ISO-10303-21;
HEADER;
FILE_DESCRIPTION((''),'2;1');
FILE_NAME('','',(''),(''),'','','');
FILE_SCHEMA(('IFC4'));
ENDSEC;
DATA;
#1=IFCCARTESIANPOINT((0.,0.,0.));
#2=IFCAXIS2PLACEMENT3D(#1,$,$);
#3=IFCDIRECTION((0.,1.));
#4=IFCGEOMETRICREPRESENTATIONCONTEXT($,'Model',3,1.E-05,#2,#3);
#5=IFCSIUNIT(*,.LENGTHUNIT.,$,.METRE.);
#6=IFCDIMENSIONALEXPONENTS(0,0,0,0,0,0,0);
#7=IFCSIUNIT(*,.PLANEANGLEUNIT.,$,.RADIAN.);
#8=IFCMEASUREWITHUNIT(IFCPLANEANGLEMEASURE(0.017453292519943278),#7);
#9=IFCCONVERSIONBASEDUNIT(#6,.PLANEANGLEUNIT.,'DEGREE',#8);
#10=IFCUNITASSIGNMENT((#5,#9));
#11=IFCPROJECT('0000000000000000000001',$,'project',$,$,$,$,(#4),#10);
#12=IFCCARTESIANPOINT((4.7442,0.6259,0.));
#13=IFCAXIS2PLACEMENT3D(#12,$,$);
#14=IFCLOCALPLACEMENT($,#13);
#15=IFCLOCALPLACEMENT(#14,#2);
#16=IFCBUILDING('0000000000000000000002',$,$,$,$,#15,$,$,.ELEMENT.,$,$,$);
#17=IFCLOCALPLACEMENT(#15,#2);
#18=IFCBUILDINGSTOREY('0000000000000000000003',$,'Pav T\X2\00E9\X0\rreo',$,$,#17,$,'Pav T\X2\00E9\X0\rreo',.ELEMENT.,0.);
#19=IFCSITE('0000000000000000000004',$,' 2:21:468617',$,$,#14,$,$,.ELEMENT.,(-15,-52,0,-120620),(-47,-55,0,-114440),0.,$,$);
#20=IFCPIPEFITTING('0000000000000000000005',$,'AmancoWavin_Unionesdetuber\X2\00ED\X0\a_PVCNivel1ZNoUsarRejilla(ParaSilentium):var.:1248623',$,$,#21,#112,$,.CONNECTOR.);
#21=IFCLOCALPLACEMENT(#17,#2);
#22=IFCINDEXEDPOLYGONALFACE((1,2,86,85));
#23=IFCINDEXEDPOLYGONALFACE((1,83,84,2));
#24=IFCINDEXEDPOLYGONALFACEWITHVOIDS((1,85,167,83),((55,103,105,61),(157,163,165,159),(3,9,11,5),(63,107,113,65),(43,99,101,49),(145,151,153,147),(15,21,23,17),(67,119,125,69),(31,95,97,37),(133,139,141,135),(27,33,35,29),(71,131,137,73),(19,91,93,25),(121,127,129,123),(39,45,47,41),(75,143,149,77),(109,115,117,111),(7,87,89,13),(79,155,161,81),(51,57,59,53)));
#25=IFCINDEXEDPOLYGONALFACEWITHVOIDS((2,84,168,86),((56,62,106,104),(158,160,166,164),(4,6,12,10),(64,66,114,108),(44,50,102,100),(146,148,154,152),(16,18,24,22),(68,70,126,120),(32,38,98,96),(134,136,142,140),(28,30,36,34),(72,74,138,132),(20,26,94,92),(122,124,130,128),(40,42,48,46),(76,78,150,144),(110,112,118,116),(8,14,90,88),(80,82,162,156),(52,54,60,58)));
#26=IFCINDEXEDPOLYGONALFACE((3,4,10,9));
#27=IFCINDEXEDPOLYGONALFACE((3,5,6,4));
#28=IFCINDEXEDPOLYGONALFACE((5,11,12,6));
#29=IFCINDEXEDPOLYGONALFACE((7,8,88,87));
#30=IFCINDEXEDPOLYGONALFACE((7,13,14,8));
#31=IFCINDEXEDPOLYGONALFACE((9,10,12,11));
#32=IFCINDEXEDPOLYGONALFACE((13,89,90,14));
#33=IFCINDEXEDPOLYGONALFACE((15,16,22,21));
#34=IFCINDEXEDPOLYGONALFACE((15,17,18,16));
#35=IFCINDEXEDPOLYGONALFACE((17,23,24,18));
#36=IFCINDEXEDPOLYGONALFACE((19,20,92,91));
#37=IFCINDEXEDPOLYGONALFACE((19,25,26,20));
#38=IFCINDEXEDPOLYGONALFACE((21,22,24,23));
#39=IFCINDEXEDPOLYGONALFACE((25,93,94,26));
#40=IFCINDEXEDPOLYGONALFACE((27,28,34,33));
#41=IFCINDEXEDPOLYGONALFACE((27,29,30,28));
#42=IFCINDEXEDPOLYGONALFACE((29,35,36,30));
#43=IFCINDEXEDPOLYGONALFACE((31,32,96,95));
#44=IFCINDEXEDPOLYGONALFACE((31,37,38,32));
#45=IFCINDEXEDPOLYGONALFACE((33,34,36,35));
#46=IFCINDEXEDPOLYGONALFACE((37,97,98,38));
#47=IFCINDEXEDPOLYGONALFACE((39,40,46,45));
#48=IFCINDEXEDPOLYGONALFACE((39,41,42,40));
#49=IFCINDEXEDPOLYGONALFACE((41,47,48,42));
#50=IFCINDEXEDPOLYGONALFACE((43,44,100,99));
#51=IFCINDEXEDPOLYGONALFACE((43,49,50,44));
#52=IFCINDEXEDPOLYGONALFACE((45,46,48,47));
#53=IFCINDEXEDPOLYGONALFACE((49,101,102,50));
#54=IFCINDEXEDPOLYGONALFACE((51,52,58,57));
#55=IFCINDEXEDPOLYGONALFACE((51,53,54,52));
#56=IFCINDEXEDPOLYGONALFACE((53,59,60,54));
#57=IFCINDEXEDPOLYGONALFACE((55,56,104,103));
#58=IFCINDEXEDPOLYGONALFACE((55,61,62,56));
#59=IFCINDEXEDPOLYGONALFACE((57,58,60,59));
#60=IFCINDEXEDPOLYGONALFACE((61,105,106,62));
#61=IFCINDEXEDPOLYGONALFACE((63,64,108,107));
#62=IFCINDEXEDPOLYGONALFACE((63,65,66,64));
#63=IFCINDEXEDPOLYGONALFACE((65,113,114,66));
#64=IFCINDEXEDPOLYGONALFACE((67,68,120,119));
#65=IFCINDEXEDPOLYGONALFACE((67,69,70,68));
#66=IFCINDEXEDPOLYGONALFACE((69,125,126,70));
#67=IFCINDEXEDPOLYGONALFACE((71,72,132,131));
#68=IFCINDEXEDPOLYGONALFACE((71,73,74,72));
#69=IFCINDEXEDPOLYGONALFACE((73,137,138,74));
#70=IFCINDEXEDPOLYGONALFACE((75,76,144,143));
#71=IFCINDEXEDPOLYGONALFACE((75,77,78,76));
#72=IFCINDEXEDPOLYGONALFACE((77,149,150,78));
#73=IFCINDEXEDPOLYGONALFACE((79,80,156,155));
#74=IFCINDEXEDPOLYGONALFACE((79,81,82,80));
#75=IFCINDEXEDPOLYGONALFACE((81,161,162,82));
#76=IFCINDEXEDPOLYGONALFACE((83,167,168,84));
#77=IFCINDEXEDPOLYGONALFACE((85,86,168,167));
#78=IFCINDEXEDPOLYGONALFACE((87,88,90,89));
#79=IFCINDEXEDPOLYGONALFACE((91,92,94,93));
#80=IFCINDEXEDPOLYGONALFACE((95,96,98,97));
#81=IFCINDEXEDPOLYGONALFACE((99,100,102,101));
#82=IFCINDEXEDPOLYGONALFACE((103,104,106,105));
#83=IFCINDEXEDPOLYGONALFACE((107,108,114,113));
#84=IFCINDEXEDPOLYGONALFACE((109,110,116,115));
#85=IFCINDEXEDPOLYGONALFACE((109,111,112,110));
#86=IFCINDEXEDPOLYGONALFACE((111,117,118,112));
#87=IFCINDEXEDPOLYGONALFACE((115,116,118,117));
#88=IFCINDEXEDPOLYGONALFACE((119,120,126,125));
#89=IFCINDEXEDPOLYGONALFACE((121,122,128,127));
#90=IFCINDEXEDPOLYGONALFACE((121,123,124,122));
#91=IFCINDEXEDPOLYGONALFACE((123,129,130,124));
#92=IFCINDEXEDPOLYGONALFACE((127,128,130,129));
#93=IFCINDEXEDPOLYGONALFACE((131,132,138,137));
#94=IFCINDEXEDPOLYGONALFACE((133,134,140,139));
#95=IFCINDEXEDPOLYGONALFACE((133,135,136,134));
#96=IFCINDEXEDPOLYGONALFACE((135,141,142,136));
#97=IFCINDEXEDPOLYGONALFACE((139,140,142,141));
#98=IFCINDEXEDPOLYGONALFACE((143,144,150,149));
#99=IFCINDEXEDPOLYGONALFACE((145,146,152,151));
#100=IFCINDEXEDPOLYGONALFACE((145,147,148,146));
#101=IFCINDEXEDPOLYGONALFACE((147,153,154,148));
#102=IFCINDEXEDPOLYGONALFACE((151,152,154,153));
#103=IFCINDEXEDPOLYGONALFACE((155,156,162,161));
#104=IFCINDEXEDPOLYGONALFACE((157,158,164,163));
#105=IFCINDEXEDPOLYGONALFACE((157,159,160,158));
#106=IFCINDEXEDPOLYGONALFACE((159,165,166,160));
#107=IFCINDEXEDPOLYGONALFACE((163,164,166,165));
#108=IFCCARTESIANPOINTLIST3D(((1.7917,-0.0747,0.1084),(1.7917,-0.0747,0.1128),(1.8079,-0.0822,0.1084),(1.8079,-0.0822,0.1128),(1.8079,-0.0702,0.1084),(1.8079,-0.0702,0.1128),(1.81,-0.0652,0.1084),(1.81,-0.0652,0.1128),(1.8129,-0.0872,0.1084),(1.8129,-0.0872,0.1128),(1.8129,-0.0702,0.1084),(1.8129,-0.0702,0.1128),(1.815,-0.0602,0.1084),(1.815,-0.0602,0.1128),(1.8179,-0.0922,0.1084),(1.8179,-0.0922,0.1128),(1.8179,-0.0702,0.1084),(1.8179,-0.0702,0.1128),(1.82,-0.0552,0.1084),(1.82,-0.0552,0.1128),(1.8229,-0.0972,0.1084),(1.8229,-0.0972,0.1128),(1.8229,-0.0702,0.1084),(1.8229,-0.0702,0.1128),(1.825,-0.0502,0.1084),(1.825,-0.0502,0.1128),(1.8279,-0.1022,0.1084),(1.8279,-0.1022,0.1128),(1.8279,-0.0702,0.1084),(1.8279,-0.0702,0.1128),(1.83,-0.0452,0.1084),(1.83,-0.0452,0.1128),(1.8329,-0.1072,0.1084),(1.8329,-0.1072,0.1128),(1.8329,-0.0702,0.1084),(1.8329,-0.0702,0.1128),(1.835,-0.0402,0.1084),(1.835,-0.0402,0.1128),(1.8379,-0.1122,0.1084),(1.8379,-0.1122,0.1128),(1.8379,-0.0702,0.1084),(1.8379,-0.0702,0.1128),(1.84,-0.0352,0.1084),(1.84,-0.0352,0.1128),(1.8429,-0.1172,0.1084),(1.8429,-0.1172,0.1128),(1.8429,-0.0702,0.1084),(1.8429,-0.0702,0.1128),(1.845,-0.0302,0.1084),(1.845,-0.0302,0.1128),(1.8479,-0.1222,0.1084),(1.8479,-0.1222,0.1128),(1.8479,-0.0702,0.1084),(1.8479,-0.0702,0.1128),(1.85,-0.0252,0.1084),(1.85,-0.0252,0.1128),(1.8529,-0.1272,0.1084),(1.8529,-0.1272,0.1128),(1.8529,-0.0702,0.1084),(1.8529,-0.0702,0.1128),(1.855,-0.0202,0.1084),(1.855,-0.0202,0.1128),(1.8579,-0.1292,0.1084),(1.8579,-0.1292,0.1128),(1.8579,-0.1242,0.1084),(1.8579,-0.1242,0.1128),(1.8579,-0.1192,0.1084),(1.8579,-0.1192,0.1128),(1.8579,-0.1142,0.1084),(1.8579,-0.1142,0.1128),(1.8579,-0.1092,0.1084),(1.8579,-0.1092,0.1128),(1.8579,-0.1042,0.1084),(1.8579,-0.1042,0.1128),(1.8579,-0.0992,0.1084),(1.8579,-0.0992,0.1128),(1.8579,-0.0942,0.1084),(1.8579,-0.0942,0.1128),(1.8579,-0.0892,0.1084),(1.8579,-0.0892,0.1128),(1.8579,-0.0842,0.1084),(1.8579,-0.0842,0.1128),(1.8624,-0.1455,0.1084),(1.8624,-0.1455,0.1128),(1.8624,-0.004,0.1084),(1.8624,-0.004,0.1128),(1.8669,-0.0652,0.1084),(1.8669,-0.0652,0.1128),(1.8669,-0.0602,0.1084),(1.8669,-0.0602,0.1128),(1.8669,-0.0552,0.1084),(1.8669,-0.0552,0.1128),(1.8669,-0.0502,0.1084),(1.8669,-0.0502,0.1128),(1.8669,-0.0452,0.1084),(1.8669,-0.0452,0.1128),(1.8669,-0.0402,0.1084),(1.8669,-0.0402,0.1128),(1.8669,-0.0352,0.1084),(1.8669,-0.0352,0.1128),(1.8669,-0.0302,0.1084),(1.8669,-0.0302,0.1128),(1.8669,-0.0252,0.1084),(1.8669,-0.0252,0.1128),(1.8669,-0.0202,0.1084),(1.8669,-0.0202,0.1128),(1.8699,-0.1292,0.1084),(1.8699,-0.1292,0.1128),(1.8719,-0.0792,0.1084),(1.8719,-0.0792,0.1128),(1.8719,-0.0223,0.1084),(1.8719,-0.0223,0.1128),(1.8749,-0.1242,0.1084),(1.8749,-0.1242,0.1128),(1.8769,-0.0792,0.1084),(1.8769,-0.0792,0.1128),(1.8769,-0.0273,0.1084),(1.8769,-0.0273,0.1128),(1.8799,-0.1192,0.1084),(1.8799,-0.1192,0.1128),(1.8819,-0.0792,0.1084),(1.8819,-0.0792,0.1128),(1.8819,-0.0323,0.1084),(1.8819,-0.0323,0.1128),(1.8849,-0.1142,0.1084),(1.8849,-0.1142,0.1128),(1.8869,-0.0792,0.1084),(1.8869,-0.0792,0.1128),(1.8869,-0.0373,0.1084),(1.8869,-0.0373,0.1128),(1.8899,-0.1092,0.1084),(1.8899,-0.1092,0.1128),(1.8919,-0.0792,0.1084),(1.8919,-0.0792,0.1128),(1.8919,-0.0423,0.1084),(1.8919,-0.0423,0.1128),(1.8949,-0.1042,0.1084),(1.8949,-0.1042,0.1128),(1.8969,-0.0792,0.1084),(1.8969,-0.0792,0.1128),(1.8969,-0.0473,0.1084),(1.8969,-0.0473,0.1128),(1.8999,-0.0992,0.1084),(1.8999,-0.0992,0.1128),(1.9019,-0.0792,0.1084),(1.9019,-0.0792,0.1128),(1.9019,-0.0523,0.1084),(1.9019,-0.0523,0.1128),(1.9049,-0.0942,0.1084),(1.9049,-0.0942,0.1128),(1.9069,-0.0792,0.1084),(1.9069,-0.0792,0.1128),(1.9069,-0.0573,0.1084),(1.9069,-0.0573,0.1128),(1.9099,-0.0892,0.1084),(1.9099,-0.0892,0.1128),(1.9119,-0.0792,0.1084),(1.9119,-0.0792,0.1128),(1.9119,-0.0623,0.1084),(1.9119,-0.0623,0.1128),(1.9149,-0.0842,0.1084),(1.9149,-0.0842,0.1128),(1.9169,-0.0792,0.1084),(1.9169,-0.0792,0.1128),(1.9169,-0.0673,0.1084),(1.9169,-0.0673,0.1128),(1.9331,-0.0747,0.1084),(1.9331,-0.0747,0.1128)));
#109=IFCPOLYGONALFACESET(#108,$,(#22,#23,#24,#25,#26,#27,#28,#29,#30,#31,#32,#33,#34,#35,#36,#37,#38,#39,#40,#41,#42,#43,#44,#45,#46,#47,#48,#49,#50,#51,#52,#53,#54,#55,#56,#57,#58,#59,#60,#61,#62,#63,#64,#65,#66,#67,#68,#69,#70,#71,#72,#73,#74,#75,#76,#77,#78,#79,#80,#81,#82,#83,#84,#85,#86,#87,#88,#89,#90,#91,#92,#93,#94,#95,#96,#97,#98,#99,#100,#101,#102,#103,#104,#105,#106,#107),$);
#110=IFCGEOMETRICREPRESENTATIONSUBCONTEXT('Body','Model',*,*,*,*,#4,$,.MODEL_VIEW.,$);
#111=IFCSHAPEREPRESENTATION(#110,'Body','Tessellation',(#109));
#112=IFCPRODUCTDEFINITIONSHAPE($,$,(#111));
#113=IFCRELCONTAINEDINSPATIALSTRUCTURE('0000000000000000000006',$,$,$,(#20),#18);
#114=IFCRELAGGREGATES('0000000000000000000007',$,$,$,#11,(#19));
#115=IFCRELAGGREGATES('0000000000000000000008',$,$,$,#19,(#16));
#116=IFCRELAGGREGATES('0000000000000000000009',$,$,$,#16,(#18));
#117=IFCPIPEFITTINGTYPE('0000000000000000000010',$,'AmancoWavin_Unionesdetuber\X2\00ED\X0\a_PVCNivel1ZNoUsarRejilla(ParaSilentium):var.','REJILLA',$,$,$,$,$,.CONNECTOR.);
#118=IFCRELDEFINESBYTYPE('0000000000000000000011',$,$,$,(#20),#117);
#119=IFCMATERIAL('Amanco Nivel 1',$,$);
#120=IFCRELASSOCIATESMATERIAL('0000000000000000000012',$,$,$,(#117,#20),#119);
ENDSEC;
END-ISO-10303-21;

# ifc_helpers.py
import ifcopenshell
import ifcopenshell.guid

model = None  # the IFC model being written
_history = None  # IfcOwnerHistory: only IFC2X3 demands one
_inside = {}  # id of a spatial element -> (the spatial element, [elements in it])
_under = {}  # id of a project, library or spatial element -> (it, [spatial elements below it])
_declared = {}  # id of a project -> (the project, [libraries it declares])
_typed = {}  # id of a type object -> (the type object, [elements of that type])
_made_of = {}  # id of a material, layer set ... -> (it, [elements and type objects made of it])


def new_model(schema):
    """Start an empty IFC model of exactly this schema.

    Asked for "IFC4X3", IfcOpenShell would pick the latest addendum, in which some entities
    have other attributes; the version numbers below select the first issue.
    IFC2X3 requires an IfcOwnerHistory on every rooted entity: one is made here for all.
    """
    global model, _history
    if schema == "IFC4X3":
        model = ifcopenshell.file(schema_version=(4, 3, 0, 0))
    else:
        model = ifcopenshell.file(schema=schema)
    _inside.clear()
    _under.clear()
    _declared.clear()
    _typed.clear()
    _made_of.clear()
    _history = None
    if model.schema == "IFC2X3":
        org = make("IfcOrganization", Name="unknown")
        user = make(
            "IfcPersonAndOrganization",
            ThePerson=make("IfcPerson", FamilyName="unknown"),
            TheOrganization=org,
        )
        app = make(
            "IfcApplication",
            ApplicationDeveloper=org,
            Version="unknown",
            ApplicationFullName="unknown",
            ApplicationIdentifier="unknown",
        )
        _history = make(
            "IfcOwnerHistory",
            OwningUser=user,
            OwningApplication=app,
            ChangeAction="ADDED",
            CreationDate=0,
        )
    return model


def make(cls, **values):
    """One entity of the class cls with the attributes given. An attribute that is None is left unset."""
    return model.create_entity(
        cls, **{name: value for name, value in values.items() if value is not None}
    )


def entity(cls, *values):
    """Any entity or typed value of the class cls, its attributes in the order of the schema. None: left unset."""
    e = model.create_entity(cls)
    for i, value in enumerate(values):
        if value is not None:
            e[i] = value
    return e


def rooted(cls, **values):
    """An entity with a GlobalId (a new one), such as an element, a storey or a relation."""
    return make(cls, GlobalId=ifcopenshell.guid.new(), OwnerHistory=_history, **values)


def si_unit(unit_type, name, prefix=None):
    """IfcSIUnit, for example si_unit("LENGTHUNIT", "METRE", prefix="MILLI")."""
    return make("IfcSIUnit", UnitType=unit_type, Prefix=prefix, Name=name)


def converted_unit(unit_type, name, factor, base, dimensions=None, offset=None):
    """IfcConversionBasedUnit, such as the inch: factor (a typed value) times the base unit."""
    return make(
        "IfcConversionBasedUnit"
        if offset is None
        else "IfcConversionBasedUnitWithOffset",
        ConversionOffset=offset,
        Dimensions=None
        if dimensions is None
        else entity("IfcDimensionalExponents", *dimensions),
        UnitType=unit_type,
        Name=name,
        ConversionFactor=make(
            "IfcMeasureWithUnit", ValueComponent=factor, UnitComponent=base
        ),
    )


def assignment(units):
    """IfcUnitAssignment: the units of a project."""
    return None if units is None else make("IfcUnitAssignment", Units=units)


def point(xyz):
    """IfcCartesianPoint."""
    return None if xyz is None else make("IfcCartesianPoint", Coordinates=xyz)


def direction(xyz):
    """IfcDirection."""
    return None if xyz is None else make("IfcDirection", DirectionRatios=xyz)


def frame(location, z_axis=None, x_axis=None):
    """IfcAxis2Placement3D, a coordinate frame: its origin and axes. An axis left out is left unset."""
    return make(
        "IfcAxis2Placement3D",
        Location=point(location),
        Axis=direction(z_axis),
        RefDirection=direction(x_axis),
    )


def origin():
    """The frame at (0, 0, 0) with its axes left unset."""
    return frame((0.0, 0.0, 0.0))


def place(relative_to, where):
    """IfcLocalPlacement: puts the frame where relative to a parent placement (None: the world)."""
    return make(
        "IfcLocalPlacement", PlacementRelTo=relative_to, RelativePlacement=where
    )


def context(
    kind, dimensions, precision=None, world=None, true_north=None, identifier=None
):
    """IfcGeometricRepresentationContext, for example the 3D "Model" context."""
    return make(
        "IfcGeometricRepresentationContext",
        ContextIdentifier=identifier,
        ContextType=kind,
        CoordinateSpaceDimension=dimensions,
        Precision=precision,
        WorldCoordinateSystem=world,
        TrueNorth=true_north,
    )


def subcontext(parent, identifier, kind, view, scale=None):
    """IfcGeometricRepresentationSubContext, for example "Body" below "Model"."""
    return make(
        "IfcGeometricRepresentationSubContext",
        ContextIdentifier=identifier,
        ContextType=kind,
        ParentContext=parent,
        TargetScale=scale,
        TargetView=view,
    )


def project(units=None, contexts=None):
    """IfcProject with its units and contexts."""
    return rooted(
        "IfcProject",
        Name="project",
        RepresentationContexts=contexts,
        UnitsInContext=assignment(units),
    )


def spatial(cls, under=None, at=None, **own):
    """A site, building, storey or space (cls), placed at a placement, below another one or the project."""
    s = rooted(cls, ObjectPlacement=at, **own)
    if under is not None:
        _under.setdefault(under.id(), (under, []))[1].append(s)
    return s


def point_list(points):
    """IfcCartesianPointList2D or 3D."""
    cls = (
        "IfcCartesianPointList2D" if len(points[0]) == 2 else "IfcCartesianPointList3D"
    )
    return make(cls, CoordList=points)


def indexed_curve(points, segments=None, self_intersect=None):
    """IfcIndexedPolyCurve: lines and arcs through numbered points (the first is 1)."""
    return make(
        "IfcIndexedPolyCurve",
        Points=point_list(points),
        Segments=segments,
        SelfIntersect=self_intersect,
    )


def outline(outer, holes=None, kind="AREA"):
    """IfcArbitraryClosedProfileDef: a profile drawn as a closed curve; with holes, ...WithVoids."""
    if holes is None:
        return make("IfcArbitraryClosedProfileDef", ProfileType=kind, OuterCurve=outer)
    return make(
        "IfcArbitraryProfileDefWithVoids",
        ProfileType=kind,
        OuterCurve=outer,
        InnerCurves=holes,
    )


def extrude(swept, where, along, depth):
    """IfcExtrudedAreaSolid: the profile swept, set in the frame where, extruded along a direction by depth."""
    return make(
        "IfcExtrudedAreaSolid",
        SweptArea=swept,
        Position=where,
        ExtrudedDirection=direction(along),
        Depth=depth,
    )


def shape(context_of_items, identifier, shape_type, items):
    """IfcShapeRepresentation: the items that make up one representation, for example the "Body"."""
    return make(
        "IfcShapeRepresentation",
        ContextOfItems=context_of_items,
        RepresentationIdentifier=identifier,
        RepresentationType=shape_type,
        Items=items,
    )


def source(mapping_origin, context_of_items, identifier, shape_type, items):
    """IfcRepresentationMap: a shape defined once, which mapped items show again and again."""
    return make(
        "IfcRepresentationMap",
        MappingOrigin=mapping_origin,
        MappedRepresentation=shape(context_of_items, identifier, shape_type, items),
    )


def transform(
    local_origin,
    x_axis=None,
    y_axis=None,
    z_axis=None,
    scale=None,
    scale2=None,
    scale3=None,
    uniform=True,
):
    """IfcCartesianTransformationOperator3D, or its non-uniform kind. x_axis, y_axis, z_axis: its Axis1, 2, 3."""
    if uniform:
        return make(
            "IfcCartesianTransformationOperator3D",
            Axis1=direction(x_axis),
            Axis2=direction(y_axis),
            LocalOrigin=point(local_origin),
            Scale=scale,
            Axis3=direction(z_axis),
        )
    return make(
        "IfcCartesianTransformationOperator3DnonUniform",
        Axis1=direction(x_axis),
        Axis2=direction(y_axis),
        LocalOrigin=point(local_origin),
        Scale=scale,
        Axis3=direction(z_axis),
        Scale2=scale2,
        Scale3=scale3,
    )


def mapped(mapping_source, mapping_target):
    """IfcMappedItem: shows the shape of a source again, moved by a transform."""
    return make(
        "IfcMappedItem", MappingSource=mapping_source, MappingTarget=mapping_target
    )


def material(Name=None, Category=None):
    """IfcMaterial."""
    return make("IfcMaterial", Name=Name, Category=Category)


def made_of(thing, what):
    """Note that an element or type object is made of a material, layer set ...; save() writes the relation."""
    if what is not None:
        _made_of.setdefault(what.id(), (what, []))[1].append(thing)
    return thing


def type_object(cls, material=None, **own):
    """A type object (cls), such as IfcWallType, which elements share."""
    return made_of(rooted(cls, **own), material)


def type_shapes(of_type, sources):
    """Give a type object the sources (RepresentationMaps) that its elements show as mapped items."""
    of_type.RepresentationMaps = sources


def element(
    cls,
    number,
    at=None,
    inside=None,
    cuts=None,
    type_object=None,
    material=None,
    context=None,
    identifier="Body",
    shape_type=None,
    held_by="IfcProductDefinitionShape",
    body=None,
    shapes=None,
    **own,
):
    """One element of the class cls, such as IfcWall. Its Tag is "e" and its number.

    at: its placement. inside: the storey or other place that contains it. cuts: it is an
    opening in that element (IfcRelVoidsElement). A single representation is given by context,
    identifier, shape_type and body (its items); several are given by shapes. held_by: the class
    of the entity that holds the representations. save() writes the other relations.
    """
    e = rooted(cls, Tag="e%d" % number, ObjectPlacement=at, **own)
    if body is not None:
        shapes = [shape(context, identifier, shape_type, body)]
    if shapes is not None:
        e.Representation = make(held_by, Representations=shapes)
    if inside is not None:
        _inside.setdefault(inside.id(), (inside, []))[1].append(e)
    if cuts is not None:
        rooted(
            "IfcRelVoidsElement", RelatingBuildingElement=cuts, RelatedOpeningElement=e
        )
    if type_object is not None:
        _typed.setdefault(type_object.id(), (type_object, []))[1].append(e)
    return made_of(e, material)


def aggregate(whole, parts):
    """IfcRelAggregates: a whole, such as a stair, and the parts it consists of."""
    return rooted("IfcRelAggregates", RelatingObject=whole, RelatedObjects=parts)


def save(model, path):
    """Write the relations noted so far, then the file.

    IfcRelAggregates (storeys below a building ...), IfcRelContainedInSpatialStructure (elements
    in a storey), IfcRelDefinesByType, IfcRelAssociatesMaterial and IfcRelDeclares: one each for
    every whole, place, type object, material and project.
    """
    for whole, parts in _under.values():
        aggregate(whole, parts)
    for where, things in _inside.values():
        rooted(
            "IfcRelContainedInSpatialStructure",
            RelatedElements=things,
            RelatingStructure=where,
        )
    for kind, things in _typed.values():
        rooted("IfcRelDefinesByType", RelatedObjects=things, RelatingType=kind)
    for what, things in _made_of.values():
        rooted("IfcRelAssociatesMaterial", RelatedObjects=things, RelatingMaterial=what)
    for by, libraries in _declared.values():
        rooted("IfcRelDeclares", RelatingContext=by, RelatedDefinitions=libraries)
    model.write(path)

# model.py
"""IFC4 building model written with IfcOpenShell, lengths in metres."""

from ifc_helpers import new_model, entity, si_unit, converted_unit, direction, frame, origin, place, context, subcontext, project, spatial, indexed_curve, outline, extrude, source, transform, mapped, material, type_object, type_shapes, element, save


model = new_model("IFC4")

# Units and contexts
model_context = context("Model", 3, precision=1e-05, world=origin(), true_north=direction((0.0, 1.0)))
body_context = subcontext(model_context, "Body", "Model", "MODEL_VIEW")
ifc_project = project(units=[si_unit("LENGTHUNIT", "METRE"), converted_unit("PLANEANGLEUNIT", "DEGREE", entity("IfcPlaneAngleMeasure", 0.017453292519943278), si_unit("PLANEANGLEUNIT", "RADIAN"), dimensions=[0, 0, 0, 0, 0, 0, 0])], contexts=[model_context])

# Site, building, storey
site_placement = place(None, frame((4.7442, 0.6259, 0.0)))
site = spatial("IfcSite", under=ifc_project, at=site_placement, Name=" 2:21:468617", CompositionType="ELEMENT", RefLatitude=(-15, -52, 0, -120620), RefLongitude=(-47, -55, 0, -114440), RefElevation=0.0)
building_placement = place(site_placement, origin())
building = spatial("IfcBuilding", under=site, at=building_placement, CompositionType="ELEMENT")
storey_placement = place(building_placement, origin())
storey = spatial("IfcBuildingStorey", under=building, at=storey_placement, Name="Pav Térreo", LongName="Pav Térreo", CompositionType="ELEMENT", Elevation=0.0)

# Pipe fitting
ifc_material_1 = material(Name="Amanco Nivel 1")
pipe_fitting_type = type_object("IfcPipeFittingType", Name="AmancoWavin_Unionesdetubería_PVCNivel1ZNoUsarRejilla(ParaSilentium):var.", Description="REJILLA", PredefinedType="CONNECTOR", material=ifc_material_1)
shared_shape = source(origin(), body_context, "Body", "SweptSolid", [
    extrude(outline(indexed_curve([(-0.05, -0.05), (0.05, -0.05), (0.05, 0.05), (-0.05, 0.05), (-0.05, -0.05)], self_intersect=False), holes=[indexed_curve([(0.0417, 0.0354), (0.0382, 0.0318), (0.0262, 0.0438), (0.0333, 0.0438), (0.0417, 0.0354)], self_intersect=False), indexed_curve([(0.0346, 0.0283), (0.0311, 0.0247), (0.0121, 0.0438), (0.0191, 0.0438), (0.0346, 0.0283)], self_intersect=False), indexed_curve([(0.0276, 0.0212), (0.024, 0.0177), (-0.0021, 0.0438), (0.005, 0.0438), (0.0276, 0.0212)], self_intersect=False), indexed_curve([(0.0205, 0.0141), (0.017, 0.0106), (-0.0162, 0.0438), (-0.0092, 0.0438), (0.0205, 0.0141)], self_intersect=False), indexed_curve([(0.0134, 0.0071), (0.0099, 0.0035), (-0.0304, 0.0438), (-0.0233, 0.0438), (0.0134, 0.0071)], self_intersect=False), indexed_curve([(-0.0354, 0.0417), (-0.0318, 0.0382), (-0.0438, 0.0262), (-0.0438, 0.0333), (-0.0354, 0.0417)], self_intersect=False), indexed_curve([(-0.0283, 0.0346), (-0.0247, 0.0311), (-0.0438, 0.0121), (-0.0438, 0.0191), (-0.0283, 0.0346)], self_intersect=False), indexed_curve([(-0.0212, 0.0276), (-0.0177, 0.024), (-0.0438, -0.0021), (-0.0438, 0.005), (-0.0212, 0.0276)], self_intersect=False), indexed_curve([(-0.0141, 0.0205), (-0.0106, 0.017), (-0.0438, -0.0162), (-0.0438, -0.0092), (-0.0141, 0.0205)], self_intersect=False), indexed_curve([(-0.0071, 0.0134), (-0.0035, 0.0099), (-0.0438, -0.0304), (-0.0438, -0.0233), (-0.0071, 0.0134)], self_intersect=False), indexed_curve([(-0.0417, -0.0354), (-0.0382, -0.0318), (-0.0262, -0.0438), (-0.0333, -0.0438), (-0.0417, -0.0354)], self_intersect=False), indexed_curve([(-0.0346, -0.0283), (-0.0311, -0.0247), (-0.0121, -0.0438), (-0.0191, -0.0438), (-0.0346, -0.0283)], self_intersect=False), indexed_curve([(-0.0276, -0.0212), (-0.024, -0.0177), (0.0021, -0.0438), (-0.005, -0.0438), (-0.0276, -0.0212)], self_intersect=False), indexed_curve([(-0.0205, -0.0141), (-0.017, -0.0106), (0.0162, -0.0438), (0.0092, -0.0438), (-0.0205, -0.0141)], self_intersect=False), indexed_curve([(-0.0134, -0.0071), (-0.0099, -0.0035), (0.0304, -0.0438), (0.0233, -0.0438), (-0.0134, -0.0071)], self_intersect=False), indexed_curve([(0.0354, -0.0417), (0.0318, -0.0382), (0.0438, -0.0262), (0.0438, -0.0333), (0.0354, -0.0417)], self_intersect=False), indexed_curve([(0.0283, -0.0346), (0.0247, -0.0311), (0.0438, -0.0121), (0.0438, -0.0191), (0.0283, -0.0346)], self_intersect=False), indexed_curve([(0.0212, -0.0276), (0.0177, -0.024), (0.0438, 0.0021), (0.0438, -0.005), (0.0212, -0.0276)], self_intersect=False), indexed_curve([(0.0141, -0.0205), (0.0106, -0.017), (0.0438, 0.0162), (0.0438, 0.0092), (0.0141, -0.0205)], self_intersect=False), indexed_curve([(0.0071, -0.0134), (0.0035, -0.0099), (0.0438, 0.0304), (0.0438, 0.0233), (0.0071, -0.0134)], self_intersect=False)]), frame((-0.0692, 0.0, -0.0042), z_axis=(0.0, 0.0, 1.0), x_axis=(-1.0, 0.0, 0.0)), (0.0, 0.0, 1.0), 0.0044),
])
type_shapes(pipe_fitting_type, [shared_shape])
pipe_fitting_placement = place(storey_placement, frame((1.9114, -0.1237, 0.1126), z_axis=(0.0, 0.0, 1.0), x_axis=(0.707107, -0.707107, 0.0)))
element("IfcPipeFitting", 1, at=pipe_fitting_placement, inside=storey, type_object=pipe_fitting_type, material=ifc_material_1, Name="AmancoWavin_Unionesdetubería_PVCNivel1ZNoUsarRejilla(ParaSilentium):var.:1248623", PredefinedType="CONNECTOR", context=body_context, shape_type="MappedRepresentation", body=[
    mapped(shared_shape, transform((0.0, 0.0, 0.0), scale=1.0)),
])

save(model, "model.ifc")
